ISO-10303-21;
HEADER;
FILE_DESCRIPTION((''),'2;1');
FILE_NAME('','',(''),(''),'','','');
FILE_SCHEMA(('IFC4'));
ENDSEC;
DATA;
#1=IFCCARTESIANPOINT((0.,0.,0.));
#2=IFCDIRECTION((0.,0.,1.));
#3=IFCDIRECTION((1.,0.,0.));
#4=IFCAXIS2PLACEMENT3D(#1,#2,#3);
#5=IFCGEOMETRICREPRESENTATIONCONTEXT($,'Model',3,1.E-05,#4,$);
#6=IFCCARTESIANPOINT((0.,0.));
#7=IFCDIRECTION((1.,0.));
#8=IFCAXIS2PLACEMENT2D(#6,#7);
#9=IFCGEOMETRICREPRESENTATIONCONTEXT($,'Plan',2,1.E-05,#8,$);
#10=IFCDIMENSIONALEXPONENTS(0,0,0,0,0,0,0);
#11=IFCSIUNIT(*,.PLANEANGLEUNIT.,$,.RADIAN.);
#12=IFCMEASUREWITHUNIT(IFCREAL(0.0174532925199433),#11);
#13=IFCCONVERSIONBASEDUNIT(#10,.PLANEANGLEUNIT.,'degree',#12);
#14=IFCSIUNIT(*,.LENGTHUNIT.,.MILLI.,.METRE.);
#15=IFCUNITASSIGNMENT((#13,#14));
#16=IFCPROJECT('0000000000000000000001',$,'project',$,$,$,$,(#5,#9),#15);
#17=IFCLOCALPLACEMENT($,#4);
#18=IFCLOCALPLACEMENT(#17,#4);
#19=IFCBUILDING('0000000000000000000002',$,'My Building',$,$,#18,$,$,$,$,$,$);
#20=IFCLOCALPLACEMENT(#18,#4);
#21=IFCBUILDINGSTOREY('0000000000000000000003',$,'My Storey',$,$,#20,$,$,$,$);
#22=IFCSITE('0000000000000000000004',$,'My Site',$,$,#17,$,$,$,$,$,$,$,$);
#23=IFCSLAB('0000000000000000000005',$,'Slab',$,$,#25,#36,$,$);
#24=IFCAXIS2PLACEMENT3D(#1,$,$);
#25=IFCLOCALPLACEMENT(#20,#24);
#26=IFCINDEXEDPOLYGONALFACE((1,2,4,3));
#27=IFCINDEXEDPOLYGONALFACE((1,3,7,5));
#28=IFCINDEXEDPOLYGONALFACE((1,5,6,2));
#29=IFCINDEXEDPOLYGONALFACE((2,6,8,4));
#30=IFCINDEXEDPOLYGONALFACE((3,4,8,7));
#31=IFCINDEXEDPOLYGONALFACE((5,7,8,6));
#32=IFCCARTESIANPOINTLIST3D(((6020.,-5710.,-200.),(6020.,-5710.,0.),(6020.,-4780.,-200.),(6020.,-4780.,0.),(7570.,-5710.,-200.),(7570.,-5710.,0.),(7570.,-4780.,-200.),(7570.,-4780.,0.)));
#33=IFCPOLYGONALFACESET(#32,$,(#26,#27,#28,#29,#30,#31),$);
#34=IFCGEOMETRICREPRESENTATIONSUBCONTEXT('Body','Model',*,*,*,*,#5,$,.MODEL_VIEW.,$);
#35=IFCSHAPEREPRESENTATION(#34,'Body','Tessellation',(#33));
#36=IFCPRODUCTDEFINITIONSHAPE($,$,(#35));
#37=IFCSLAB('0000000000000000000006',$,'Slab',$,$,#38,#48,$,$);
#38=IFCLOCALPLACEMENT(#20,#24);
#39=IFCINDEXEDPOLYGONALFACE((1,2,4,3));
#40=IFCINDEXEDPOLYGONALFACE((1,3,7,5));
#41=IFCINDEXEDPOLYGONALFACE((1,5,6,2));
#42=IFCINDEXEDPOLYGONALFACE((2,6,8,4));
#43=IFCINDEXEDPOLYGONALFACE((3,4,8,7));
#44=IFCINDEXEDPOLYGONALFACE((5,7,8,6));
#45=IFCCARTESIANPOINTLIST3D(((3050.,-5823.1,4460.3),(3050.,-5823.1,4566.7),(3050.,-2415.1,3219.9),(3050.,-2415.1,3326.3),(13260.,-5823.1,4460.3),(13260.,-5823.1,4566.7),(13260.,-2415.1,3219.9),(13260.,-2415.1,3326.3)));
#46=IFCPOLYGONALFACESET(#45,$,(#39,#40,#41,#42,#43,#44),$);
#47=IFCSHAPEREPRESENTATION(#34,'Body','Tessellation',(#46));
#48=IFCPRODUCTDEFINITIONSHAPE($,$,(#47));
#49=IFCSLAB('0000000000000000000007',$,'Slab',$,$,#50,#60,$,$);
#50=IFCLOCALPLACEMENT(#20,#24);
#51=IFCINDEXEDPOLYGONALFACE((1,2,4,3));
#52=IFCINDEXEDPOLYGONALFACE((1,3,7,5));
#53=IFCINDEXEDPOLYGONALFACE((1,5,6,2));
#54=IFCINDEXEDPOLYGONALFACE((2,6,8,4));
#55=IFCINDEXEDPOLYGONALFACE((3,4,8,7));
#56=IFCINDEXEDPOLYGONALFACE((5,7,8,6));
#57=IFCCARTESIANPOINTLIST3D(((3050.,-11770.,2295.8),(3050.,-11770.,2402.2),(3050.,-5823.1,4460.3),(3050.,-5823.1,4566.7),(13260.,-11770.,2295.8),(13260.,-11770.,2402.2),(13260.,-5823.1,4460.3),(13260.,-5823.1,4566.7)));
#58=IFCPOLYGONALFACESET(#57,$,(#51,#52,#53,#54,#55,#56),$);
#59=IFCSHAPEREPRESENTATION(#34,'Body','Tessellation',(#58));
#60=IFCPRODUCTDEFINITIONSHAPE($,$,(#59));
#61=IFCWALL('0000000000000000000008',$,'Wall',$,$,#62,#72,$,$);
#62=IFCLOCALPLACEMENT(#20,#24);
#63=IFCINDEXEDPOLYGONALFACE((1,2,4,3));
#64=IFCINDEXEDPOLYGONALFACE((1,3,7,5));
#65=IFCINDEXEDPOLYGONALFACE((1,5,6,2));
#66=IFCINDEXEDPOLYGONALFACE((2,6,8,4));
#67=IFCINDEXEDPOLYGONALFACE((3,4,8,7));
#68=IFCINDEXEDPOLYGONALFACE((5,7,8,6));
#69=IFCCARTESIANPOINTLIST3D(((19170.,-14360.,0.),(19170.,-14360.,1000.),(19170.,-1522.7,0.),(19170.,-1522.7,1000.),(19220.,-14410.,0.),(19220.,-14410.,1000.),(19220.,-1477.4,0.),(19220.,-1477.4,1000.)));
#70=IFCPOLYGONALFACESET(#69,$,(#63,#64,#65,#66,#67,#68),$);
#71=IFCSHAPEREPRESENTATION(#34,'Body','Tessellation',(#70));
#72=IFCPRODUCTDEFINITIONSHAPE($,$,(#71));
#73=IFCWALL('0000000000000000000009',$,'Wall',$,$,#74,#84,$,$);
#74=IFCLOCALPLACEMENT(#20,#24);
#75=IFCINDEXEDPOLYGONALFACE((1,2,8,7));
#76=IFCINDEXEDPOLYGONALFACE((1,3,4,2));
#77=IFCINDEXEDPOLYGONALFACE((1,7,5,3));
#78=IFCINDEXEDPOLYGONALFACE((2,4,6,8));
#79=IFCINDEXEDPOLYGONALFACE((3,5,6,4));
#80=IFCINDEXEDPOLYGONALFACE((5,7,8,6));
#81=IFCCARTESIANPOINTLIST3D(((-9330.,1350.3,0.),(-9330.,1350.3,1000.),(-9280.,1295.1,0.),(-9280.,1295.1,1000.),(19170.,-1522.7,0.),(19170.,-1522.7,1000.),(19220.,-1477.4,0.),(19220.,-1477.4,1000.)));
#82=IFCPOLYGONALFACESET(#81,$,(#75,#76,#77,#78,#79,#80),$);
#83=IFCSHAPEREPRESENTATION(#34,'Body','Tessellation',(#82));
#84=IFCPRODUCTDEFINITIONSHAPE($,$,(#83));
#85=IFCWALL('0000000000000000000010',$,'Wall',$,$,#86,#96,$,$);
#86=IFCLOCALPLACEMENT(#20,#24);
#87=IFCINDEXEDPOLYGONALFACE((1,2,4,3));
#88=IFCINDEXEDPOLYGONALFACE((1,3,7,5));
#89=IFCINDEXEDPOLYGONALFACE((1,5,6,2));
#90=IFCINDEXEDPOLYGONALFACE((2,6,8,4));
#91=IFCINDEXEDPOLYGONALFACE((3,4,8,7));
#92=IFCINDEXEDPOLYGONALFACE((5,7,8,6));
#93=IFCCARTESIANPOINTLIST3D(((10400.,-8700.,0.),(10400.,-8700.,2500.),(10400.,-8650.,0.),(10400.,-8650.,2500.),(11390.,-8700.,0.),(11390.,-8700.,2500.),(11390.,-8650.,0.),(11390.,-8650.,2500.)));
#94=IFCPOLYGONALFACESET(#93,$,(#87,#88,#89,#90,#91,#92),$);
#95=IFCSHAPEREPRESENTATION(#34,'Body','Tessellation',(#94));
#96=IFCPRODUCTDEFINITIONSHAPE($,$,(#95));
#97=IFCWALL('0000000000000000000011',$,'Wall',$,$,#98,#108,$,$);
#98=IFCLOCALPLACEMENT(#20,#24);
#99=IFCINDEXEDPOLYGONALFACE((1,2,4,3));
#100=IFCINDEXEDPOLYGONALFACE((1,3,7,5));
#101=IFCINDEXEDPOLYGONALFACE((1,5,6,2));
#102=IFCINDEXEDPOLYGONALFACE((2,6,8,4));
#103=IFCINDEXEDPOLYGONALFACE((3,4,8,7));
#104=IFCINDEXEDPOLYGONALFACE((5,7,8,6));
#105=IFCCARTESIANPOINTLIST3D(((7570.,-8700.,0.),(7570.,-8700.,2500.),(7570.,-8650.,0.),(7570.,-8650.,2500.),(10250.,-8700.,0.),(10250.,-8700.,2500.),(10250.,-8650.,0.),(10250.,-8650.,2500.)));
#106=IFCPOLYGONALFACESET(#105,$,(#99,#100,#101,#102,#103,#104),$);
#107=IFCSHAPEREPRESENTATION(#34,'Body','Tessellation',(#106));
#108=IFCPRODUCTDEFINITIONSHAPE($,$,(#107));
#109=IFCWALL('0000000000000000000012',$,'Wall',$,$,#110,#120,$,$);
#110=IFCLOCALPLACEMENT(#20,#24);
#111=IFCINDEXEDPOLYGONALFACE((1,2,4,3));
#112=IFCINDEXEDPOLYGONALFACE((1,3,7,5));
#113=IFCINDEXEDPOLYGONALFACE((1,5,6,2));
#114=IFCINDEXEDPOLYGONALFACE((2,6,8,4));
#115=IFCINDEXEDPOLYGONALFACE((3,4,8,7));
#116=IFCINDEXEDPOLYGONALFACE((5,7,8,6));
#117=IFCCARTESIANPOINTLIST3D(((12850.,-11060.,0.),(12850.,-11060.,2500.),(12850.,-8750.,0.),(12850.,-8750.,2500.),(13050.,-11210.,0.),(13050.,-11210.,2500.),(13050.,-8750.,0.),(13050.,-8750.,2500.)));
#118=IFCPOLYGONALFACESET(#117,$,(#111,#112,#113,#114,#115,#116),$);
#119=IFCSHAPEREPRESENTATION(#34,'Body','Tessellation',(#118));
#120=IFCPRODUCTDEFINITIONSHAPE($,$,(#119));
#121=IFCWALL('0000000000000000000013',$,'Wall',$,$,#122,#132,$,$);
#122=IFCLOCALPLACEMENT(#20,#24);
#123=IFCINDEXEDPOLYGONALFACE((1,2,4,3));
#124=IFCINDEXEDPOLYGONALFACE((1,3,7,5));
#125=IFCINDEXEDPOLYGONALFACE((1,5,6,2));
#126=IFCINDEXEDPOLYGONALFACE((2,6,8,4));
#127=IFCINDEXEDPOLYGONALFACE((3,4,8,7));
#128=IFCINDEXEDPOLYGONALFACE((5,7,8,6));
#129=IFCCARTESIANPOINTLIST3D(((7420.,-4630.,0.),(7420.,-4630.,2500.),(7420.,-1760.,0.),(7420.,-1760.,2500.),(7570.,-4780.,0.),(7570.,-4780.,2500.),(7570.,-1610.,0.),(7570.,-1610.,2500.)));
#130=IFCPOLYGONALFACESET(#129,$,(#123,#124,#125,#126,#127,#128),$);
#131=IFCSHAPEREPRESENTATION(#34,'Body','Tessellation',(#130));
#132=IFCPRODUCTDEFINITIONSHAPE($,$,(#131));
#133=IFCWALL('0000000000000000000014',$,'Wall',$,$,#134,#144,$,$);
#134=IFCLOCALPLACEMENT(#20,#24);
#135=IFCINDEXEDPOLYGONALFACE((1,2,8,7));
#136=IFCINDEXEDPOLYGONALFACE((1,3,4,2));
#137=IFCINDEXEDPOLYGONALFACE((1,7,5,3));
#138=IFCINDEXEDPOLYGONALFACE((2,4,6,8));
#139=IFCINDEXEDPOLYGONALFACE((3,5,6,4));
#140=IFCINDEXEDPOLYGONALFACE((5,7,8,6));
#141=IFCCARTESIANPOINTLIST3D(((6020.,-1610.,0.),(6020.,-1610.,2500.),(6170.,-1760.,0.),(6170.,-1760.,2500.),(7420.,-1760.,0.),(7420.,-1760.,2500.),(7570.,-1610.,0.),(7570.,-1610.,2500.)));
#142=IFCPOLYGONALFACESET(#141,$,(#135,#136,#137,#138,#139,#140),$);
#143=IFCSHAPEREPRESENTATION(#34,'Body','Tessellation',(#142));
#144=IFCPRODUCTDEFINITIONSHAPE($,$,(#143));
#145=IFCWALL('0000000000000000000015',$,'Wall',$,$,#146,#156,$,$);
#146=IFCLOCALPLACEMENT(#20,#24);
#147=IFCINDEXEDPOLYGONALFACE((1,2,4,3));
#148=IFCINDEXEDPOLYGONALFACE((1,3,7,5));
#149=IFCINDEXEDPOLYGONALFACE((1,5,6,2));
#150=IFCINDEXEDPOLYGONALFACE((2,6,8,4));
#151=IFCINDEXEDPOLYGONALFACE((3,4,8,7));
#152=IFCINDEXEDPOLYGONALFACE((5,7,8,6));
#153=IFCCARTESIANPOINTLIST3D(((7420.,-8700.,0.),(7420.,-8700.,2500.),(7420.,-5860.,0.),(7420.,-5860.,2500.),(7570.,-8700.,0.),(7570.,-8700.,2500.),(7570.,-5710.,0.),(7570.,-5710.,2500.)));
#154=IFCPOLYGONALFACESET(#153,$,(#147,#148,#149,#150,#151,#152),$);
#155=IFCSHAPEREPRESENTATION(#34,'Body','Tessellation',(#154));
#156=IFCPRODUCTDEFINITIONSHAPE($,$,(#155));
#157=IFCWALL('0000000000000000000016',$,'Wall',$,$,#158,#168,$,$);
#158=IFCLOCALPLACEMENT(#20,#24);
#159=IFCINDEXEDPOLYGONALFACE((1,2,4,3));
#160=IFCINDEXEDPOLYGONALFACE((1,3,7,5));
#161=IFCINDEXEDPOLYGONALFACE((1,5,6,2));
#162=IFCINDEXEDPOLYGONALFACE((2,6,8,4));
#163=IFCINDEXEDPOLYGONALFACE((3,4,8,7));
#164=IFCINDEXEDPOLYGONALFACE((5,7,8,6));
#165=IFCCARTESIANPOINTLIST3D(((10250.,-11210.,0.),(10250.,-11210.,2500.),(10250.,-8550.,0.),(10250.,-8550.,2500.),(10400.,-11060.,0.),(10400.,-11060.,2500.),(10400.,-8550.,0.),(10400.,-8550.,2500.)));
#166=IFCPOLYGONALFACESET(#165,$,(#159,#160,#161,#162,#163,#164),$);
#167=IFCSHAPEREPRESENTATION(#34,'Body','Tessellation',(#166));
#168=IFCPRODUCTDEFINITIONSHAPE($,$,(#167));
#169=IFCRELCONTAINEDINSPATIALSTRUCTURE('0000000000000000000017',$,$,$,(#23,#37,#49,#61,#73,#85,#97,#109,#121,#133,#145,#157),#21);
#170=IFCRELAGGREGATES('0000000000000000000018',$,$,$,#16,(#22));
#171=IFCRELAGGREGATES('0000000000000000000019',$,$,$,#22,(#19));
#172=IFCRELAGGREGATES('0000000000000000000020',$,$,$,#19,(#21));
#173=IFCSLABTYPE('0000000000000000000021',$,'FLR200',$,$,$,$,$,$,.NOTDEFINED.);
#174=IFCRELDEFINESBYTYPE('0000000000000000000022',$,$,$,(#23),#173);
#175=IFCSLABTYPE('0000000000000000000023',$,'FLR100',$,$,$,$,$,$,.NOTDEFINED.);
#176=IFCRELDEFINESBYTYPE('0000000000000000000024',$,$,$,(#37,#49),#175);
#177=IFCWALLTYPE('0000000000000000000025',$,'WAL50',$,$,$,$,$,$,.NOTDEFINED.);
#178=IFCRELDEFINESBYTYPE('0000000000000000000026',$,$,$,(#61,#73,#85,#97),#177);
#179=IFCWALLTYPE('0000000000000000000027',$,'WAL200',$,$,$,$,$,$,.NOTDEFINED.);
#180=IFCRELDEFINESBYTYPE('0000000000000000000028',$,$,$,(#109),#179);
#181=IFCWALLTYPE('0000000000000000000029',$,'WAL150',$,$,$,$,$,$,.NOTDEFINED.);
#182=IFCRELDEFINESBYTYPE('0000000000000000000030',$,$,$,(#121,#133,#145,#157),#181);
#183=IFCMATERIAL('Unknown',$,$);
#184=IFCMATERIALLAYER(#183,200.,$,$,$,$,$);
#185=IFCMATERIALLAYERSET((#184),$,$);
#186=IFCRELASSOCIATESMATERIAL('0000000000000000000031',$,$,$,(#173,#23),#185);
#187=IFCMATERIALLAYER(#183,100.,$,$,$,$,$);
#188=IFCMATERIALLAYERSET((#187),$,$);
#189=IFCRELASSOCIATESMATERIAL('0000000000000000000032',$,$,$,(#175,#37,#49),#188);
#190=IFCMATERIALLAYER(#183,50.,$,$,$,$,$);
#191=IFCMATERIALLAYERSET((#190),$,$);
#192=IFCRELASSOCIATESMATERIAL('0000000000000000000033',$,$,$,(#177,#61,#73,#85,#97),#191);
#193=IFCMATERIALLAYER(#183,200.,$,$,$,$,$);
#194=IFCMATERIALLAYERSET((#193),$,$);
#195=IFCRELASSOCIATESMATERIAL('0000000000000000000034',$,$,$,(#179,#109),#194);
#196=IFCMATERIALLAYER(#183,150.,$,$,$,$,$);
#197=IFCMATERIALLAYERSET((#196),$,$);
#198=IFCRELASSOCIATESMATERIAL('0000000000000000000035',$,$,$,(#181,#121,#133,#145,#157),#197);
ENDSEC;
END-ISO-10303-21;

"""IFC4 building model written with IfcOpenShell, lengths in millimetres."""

from ifc_helpers import new_model, entity, si_unit, converted_unit, frame, origin_with_axes, origin_2d_with_axis, place, context, subcontext, project, spatial, line, indexed_curve, outline, extrude, material, layer, layer_set, layer_usage, type_object, element, save


model = new_model("IFC4")

# Units and contexts
model_context = context("Model", 3, precision=1e-05, world=origin_with_axes())
plan_context = context("Plan", 2, precision=1e-05, world=origin_2d_with_axis())
body_context_1 = subcontext(model_context, "Body", "Model", "MODEL_VIEW")
ifc_project = project(units=[converted_unit("PLANEANGLEUNIT", "degree", entity("IfcReal", 0.0174532925199433), si_unit("PLANEANGLEUNIT", "RADIAN"), dimensions=[0, 0, 0, 0, 0, 0, 0]), si_unit("LENGTHUNIT", "METRE", prefix="MILLI")], contexts=[model_context, plan_context])

# Site, building, storey
site_placement = place(None, origin_with_axes())
site = spatial("IfcSite", under=ifc_project, at=site_placement, Name="My Site")
building_placement = place(site_placement, origin_with_axes())
building = spatial("IfcBuilding", under=site, at=building_placement, Name="My Building")
storey_placement = place(building_placement, origin_with_axes())
storey = spatial("IfcBuildingStorey", under=building, at=storey_placement, Name="My Storey")

# Shared definitions
ifc_material = material(Name="Unknown")

# Slabs
ifc_layer_1 = layer(ifc_material, 200.0)
ifc_layer_set_1 = layer_set([ifc_layer_1])
slab_type_1 = type_object("IfcSlabType", Name="FLR200", PredefinedType="NOTDEFINED", material=ifc_layer_set_1)
ifc_layer_usage_1 = layer_usage(ifc_layer_set_1, "AXIS3", "POSITIVE", -200.0)
slab_1_placement = place(storey_placement, frame((7570.0, -4780.0, 0.0), z_axis=(0.0, 0.0, 1.0), x_axis=(1.0, 0.0, 0.0)))
element("IfcSlab", 1, at=slab_1_placement, inside=storey, type_object=slab_type_1, material=ifc_layer_usage_1, Name="Slab", context=body_context_1, shape_type="SweptSolid", body=[
    extrude(outline(indexed_curve([(0.0, 0.0), (0.0, -930.0), (-1550.0, -930.0), (-1550.0, 0.0), (0.0, 0.0)])), frame((0.0, 0.0, -200.0), z_axis=(0.0, 0.0, 1.0), x_axis=(1.0, 0.0, 0.0)), (0.0, 0.0, 1.0), 200.0),
])
ifc_layer_2 = layer(ifc_material, 100.0)
ifc_layer_set_2 = layer_set([ifc_layer_2])
ifc_layer_usage_2 = layer_usage(ifc_layer_set_2, "AXIS3", "POSITIVE", -100.0)
slab_type_2 = type_object("IfcSlabType", Name="FLR100", PredefinedType="NOTDEFINED", material=ifc_layer_set_2)
slab_2_placement = place(storey_placement, frame((13260.0, -5823.1, 4566.7), z_axis=(0.0, 0.34202, 0.939693), x_axis=(1.0, 0.0, 0.0)))
element("IfcSlab", 2, at=slab_2_placement, inside=storey, type_object=slab_type_2, material=ifc_layer_usage_2, Name="Slab", context=body_context_1, shape_type="SweptSolid", body=[
    extrude(outline(indexed_curve([(-10210.1, 0.0), (-10210.1, 3626.7), (0.0, 3626.7), (0.0, 0.0), (-10210.1, 0.0)])), frame((0.0, 36.4, -100.0), z_axis=(0.0, 0.0, 1.0), x_axis=(1.0, 0.0, 0.0)), (0.0, -0.34202, 0.939693), 106.4),
])
ifc_layer_usage_3 = layer_usage(ifc_layer_set_2, "AXIS3", "POSITIVE", -100.0)
slab_3_placement = place(storey_placement, frame((13260.0, -5823.1, 4566.7), z_axis=(0.0, -0.34202, 0.939693), x_axis=(1.0, 0.0, 0.0)))
element("IfcSlab", 3, at=slab_3_placement, inside=storey, type_object=slab_type_2, material=ifc_layer_usage_3, Name="Slab", context=body_context_1, shape_type="SweptSolid", body=[
    extrude(outline(indexed_curve([(0.0, 0.0), (-10210.1, 0.0), (-10210.1, -6328.6), (0.0, -6328.6), (0.0, 0.0)])), frame((0.0, -36.4, -100.0), z_axis=(0.0, 0.0, 1.0), x_axis=(1.0, 0.0, 0.0)), (0.0, 0.34202, 0.939693), 106.4),
])

# Walls
ifc_layer_3 = layer(ifc_material, 50.0)
ifc_layer_set_3 = layer_set([ifc_layer_3])
ifc_layer_usage_4 = layer_usage(ifc_layer_set_3, "AXIS2", "POSITIVE", 0.0)
wall_type_1 = type_object("IfcWallType", Name="WAL50", PredefinedType="NOTDEFINED", material=ifc_layer_set_3)
wall_1_placement = place(storey_placement, frame((19220.0, -14410.0, 0.0), z_axis=(0.0, 0.0, 1.0), x_axis=(0.0, 1.0, 0.0)))
element("IfcWall", 4, at=wall_1_placement, inside=storey, type_object=wall_type_1, material=ifc_layer_usage_4, Name="Wall", context=body_context_1, shape_type="SweptSolid", body=[
    extrude(outline(indexed_curve([(0.0, 0.0), (50.0, 50.0), (12887.3, 50.0), (12932.6, 0.0)], segments=[line(1, 2, 3, 4, 1)])), origin_with_axes(), (0.0, 0.0, 1.0), 1000.0),
])
ifc_layer_usage_5 = layer_usage(ifc_layer_set_3, "AXIS2", "POSITIVE", 0.0)
wall_2_placement = place(storey_placement, frame((19220.0, -1477.4, 0.0), z_axis=(0.0, 0.0, 1.0), x_axis=(-0.995131, 0.098562, 0.0)))
element("IfcWall", 5, at=wall_2_placement, inside=storey, type_object=wall_type_1, material=ifc_layer_usage_5, Name="Wall", context=body_context_1, shape_type="SweptSolid", body=[
    extrude(outline(indexed_curve([(0.0, 0.0), (45.3, 50.0), (28634.5, 50.0), (28689.7, 0.0)], segments=[line(1, 2, 3, 4, 1)])), origin_with_axes(), (0.0, 0.0, 1.0), 1000.0),
])
ifc_layer_usage_6 = layer_usage(ifc_layer_set_3, "AXIS2", "POSITIVE", 0.0)
wall_3_placement = place(storey_placement, frame((10400.0, -8700.0, 0.0), z_axis=(0.0, 0.0, 1.0), x_axis=(1.0, 0.0, 0.0)))
element("IfcWall", 6, at=wall_3_placement, inside=storey, type_object=wall_type_1, material=ifc_layer_usage_6, Name="Wall", context=body_context_1, shape_type="SweptSolid", body=[
    extrude(outline(indexed_curve([(0.0, 0.0), (0.0, 50.0), (990.0, 50.0), (990.0, 0.0)], segments=[line(1, 2, 3, 4, 1)])), origin_with_axes(), (0.0, 0.0, 1.0), 2500.0),
])
ifc_layer_usage_7 = layer_usage(ifc_layer_set_3, "AXIS2", "POSITIVE", 0.0)
wall_4_placement = place(storey_placement, frame((7570.0, -8700.0, 0.0), z_axis=(0.0, 0.0, 1.0), x_axis=(1.0, 0.0, 0.0)))
element("IfcWall", 7, at=wall_4_placement, inside=storey, type_object=wall_type_1, material=ifc_layer_usage_7, Name="Wall", context=body_context_1, shape_type="SweptSolid", body=[
    extrude(outline(indexed_curve([(0.0, 0.0), (0.0, 50.0), (2680.0, 50.0), (2680.0, 0.0)], segments=[line(1, 2, 3, 4, 1)])), origin_with_axes(), (0.0, 0.0, 1.0), 2500.0),
])
ifc_layer_4 = layer(ifc_material, 200.0)
ifc_layer_set_4 = layer_set([ifc_layer_4])
ifc_layer_usage_8 = layer_usage(ifc_layer_set_4, "AXIS2", "POSITIVE", 0.0)
wall_type_2 = type_object("IfcWallType", Name="WAL200", PredefinedType="NOTDEFINED", material=ifc_layer_set_4)
wall_5_placement = place(storey_placement, frame((13050.0, -11210.0, 0.0), z_axis=(0.0, 0.0, 1.0), x_axis=(0.0, 1.0, 0.0)))
element("IfcWall", 8, at=wall_5_placement, inside=storey, type_object=wall_type_2, material=ifc_layer_usage_8, Name="Wall", context=body_context_1, shape_type="SweptSolid", body=[
    extrude(outline(indexed_curve([(0.0, 0.0), (150.0, 200.0), (2460.0, 200.0), (2460.0, 0.0)], segments=[line(1, 2, 3, 4, 1)])), origin_with_axes(), (0.0, 0.0, 1.0), 2500.0),
])
ifc_layer_5 = layer(ifc_material, 150.0)
ifc_layer_set_5 = layer_set([ifc_layer_5])
ifc_layer_usage_9 = layer_usage(ifc_layer_set_5, "AXIS2", "POSITIVE", 0.0)
wall_type_3 = type_object("IfcWallType", Name="WAL150", PredefinedType="NOTDEFINED", material=ifc_layer_set_5)
wall_6_placement = place(storey_placement, frame((7570.0, -4780.0, 0.0), z_axis=(0.0, 0.0, 1.0), x_axis=(0.0, 1.0, 0.0)))
element("IfcWall", 9, at=wall_6_placement, inside=storey, type_object=wall_type_3, material=ifc_layer_usage_9, Name="Wall", context=body_context_1, shape_type="SweptSolid", body=[
    extrude(outline(indexed_curve([(0.0, 0.0), (150.0, 150.0), (3020.0, 150.0), (3170.0, 0.0)], segments=[line(1, 2, 3, 4, 1)])), origin_with_axes(), (0.0, 0.0, 1.0), 2500.0),
])
ifc_layer_usage_10 = layer_usage(ifc_layer_set_5, "AXIS2", "POSITIVE", 0.0)
wall_7_placement = place(storey_placement, frame((7570.0, -1610.0, 0.0), z_axis=(0.0, 0.0, 1.0), x_axis=(-1.0, 0.0, 0.0)))
element("IfcWall", 10, at=wall_7_placement, inside=storey, type_object=wall_type_3, material=ifc_layer_usage_10, Name="Wall", context=body_context_1, shape_type="SweptSolid", body=[
    extrude(outline(indexed_curve([(0.0, 0.0), (150.0, 150.0), (1400.0, 150.0), (1550.0, 0.0)], segments=[line(1, 2, 3, 4, 1)])), origin_with_axes(), (0.0, 0.0, 1.0), 2500.0),
])
ifc_layer_usage_11 = layer_usage(ifc_layer_set_5, "AXIS2", "POSITIVE", 0.0)
wall_8_placement = place(storey_placement, frame((7570.0, -8700.0, 0.0), z_axis=(0.0, 0.0, 1.0), x_axis=(0.0, 1.0, 0.0)))
element("IfcWall", 11, at=wall_8_placement, inside=storey, type_object=wall_type_3, material=ifc_layer_usage_11, Name="Wall", context=body_context_1, shape_type="SweptSolid", body=[
    extrude(outline(indexed_curve([(0.0, 0.0), (0.0, 150.0), (2840.0, 150.0), (2990.0, 0.0)], segments=[line(1, 2, 3, 4, 1)])), origin_with_axes(), (0.0, 0.0, 1.0), 2500.0),
])
ifc_layer_usage_12 = layer_usage(ifc_layer_set_5, "AXIS2", "POSITIVE", 0.0)
wall_9_placement = place(storey_placement, frame((10250.0, -8550.0, 0.0), z_axis=(0.0, 0.0, 1.0), x_axis=(0.0, -1.0, 0.0)))
element("IfcWall", 12, at=wall_9_placement, inside=storey, type_object=wall_type_3, material=ifc_layer_usage_12, Name="Wall", context=body_context_1, shape_type="SweptSolid", body=[
    extrude(outline(indexed_curve([(0.0, 0.0), (0.0, 150.0), (2510.0, 150.0), (2660.0, 0.0)], segments=[line(1, 2, 3, 4, 1)])), origin_with_axes(), (0.0, 0.0, 1.0), 2500.0),
])

save(model, "model.ifc")
